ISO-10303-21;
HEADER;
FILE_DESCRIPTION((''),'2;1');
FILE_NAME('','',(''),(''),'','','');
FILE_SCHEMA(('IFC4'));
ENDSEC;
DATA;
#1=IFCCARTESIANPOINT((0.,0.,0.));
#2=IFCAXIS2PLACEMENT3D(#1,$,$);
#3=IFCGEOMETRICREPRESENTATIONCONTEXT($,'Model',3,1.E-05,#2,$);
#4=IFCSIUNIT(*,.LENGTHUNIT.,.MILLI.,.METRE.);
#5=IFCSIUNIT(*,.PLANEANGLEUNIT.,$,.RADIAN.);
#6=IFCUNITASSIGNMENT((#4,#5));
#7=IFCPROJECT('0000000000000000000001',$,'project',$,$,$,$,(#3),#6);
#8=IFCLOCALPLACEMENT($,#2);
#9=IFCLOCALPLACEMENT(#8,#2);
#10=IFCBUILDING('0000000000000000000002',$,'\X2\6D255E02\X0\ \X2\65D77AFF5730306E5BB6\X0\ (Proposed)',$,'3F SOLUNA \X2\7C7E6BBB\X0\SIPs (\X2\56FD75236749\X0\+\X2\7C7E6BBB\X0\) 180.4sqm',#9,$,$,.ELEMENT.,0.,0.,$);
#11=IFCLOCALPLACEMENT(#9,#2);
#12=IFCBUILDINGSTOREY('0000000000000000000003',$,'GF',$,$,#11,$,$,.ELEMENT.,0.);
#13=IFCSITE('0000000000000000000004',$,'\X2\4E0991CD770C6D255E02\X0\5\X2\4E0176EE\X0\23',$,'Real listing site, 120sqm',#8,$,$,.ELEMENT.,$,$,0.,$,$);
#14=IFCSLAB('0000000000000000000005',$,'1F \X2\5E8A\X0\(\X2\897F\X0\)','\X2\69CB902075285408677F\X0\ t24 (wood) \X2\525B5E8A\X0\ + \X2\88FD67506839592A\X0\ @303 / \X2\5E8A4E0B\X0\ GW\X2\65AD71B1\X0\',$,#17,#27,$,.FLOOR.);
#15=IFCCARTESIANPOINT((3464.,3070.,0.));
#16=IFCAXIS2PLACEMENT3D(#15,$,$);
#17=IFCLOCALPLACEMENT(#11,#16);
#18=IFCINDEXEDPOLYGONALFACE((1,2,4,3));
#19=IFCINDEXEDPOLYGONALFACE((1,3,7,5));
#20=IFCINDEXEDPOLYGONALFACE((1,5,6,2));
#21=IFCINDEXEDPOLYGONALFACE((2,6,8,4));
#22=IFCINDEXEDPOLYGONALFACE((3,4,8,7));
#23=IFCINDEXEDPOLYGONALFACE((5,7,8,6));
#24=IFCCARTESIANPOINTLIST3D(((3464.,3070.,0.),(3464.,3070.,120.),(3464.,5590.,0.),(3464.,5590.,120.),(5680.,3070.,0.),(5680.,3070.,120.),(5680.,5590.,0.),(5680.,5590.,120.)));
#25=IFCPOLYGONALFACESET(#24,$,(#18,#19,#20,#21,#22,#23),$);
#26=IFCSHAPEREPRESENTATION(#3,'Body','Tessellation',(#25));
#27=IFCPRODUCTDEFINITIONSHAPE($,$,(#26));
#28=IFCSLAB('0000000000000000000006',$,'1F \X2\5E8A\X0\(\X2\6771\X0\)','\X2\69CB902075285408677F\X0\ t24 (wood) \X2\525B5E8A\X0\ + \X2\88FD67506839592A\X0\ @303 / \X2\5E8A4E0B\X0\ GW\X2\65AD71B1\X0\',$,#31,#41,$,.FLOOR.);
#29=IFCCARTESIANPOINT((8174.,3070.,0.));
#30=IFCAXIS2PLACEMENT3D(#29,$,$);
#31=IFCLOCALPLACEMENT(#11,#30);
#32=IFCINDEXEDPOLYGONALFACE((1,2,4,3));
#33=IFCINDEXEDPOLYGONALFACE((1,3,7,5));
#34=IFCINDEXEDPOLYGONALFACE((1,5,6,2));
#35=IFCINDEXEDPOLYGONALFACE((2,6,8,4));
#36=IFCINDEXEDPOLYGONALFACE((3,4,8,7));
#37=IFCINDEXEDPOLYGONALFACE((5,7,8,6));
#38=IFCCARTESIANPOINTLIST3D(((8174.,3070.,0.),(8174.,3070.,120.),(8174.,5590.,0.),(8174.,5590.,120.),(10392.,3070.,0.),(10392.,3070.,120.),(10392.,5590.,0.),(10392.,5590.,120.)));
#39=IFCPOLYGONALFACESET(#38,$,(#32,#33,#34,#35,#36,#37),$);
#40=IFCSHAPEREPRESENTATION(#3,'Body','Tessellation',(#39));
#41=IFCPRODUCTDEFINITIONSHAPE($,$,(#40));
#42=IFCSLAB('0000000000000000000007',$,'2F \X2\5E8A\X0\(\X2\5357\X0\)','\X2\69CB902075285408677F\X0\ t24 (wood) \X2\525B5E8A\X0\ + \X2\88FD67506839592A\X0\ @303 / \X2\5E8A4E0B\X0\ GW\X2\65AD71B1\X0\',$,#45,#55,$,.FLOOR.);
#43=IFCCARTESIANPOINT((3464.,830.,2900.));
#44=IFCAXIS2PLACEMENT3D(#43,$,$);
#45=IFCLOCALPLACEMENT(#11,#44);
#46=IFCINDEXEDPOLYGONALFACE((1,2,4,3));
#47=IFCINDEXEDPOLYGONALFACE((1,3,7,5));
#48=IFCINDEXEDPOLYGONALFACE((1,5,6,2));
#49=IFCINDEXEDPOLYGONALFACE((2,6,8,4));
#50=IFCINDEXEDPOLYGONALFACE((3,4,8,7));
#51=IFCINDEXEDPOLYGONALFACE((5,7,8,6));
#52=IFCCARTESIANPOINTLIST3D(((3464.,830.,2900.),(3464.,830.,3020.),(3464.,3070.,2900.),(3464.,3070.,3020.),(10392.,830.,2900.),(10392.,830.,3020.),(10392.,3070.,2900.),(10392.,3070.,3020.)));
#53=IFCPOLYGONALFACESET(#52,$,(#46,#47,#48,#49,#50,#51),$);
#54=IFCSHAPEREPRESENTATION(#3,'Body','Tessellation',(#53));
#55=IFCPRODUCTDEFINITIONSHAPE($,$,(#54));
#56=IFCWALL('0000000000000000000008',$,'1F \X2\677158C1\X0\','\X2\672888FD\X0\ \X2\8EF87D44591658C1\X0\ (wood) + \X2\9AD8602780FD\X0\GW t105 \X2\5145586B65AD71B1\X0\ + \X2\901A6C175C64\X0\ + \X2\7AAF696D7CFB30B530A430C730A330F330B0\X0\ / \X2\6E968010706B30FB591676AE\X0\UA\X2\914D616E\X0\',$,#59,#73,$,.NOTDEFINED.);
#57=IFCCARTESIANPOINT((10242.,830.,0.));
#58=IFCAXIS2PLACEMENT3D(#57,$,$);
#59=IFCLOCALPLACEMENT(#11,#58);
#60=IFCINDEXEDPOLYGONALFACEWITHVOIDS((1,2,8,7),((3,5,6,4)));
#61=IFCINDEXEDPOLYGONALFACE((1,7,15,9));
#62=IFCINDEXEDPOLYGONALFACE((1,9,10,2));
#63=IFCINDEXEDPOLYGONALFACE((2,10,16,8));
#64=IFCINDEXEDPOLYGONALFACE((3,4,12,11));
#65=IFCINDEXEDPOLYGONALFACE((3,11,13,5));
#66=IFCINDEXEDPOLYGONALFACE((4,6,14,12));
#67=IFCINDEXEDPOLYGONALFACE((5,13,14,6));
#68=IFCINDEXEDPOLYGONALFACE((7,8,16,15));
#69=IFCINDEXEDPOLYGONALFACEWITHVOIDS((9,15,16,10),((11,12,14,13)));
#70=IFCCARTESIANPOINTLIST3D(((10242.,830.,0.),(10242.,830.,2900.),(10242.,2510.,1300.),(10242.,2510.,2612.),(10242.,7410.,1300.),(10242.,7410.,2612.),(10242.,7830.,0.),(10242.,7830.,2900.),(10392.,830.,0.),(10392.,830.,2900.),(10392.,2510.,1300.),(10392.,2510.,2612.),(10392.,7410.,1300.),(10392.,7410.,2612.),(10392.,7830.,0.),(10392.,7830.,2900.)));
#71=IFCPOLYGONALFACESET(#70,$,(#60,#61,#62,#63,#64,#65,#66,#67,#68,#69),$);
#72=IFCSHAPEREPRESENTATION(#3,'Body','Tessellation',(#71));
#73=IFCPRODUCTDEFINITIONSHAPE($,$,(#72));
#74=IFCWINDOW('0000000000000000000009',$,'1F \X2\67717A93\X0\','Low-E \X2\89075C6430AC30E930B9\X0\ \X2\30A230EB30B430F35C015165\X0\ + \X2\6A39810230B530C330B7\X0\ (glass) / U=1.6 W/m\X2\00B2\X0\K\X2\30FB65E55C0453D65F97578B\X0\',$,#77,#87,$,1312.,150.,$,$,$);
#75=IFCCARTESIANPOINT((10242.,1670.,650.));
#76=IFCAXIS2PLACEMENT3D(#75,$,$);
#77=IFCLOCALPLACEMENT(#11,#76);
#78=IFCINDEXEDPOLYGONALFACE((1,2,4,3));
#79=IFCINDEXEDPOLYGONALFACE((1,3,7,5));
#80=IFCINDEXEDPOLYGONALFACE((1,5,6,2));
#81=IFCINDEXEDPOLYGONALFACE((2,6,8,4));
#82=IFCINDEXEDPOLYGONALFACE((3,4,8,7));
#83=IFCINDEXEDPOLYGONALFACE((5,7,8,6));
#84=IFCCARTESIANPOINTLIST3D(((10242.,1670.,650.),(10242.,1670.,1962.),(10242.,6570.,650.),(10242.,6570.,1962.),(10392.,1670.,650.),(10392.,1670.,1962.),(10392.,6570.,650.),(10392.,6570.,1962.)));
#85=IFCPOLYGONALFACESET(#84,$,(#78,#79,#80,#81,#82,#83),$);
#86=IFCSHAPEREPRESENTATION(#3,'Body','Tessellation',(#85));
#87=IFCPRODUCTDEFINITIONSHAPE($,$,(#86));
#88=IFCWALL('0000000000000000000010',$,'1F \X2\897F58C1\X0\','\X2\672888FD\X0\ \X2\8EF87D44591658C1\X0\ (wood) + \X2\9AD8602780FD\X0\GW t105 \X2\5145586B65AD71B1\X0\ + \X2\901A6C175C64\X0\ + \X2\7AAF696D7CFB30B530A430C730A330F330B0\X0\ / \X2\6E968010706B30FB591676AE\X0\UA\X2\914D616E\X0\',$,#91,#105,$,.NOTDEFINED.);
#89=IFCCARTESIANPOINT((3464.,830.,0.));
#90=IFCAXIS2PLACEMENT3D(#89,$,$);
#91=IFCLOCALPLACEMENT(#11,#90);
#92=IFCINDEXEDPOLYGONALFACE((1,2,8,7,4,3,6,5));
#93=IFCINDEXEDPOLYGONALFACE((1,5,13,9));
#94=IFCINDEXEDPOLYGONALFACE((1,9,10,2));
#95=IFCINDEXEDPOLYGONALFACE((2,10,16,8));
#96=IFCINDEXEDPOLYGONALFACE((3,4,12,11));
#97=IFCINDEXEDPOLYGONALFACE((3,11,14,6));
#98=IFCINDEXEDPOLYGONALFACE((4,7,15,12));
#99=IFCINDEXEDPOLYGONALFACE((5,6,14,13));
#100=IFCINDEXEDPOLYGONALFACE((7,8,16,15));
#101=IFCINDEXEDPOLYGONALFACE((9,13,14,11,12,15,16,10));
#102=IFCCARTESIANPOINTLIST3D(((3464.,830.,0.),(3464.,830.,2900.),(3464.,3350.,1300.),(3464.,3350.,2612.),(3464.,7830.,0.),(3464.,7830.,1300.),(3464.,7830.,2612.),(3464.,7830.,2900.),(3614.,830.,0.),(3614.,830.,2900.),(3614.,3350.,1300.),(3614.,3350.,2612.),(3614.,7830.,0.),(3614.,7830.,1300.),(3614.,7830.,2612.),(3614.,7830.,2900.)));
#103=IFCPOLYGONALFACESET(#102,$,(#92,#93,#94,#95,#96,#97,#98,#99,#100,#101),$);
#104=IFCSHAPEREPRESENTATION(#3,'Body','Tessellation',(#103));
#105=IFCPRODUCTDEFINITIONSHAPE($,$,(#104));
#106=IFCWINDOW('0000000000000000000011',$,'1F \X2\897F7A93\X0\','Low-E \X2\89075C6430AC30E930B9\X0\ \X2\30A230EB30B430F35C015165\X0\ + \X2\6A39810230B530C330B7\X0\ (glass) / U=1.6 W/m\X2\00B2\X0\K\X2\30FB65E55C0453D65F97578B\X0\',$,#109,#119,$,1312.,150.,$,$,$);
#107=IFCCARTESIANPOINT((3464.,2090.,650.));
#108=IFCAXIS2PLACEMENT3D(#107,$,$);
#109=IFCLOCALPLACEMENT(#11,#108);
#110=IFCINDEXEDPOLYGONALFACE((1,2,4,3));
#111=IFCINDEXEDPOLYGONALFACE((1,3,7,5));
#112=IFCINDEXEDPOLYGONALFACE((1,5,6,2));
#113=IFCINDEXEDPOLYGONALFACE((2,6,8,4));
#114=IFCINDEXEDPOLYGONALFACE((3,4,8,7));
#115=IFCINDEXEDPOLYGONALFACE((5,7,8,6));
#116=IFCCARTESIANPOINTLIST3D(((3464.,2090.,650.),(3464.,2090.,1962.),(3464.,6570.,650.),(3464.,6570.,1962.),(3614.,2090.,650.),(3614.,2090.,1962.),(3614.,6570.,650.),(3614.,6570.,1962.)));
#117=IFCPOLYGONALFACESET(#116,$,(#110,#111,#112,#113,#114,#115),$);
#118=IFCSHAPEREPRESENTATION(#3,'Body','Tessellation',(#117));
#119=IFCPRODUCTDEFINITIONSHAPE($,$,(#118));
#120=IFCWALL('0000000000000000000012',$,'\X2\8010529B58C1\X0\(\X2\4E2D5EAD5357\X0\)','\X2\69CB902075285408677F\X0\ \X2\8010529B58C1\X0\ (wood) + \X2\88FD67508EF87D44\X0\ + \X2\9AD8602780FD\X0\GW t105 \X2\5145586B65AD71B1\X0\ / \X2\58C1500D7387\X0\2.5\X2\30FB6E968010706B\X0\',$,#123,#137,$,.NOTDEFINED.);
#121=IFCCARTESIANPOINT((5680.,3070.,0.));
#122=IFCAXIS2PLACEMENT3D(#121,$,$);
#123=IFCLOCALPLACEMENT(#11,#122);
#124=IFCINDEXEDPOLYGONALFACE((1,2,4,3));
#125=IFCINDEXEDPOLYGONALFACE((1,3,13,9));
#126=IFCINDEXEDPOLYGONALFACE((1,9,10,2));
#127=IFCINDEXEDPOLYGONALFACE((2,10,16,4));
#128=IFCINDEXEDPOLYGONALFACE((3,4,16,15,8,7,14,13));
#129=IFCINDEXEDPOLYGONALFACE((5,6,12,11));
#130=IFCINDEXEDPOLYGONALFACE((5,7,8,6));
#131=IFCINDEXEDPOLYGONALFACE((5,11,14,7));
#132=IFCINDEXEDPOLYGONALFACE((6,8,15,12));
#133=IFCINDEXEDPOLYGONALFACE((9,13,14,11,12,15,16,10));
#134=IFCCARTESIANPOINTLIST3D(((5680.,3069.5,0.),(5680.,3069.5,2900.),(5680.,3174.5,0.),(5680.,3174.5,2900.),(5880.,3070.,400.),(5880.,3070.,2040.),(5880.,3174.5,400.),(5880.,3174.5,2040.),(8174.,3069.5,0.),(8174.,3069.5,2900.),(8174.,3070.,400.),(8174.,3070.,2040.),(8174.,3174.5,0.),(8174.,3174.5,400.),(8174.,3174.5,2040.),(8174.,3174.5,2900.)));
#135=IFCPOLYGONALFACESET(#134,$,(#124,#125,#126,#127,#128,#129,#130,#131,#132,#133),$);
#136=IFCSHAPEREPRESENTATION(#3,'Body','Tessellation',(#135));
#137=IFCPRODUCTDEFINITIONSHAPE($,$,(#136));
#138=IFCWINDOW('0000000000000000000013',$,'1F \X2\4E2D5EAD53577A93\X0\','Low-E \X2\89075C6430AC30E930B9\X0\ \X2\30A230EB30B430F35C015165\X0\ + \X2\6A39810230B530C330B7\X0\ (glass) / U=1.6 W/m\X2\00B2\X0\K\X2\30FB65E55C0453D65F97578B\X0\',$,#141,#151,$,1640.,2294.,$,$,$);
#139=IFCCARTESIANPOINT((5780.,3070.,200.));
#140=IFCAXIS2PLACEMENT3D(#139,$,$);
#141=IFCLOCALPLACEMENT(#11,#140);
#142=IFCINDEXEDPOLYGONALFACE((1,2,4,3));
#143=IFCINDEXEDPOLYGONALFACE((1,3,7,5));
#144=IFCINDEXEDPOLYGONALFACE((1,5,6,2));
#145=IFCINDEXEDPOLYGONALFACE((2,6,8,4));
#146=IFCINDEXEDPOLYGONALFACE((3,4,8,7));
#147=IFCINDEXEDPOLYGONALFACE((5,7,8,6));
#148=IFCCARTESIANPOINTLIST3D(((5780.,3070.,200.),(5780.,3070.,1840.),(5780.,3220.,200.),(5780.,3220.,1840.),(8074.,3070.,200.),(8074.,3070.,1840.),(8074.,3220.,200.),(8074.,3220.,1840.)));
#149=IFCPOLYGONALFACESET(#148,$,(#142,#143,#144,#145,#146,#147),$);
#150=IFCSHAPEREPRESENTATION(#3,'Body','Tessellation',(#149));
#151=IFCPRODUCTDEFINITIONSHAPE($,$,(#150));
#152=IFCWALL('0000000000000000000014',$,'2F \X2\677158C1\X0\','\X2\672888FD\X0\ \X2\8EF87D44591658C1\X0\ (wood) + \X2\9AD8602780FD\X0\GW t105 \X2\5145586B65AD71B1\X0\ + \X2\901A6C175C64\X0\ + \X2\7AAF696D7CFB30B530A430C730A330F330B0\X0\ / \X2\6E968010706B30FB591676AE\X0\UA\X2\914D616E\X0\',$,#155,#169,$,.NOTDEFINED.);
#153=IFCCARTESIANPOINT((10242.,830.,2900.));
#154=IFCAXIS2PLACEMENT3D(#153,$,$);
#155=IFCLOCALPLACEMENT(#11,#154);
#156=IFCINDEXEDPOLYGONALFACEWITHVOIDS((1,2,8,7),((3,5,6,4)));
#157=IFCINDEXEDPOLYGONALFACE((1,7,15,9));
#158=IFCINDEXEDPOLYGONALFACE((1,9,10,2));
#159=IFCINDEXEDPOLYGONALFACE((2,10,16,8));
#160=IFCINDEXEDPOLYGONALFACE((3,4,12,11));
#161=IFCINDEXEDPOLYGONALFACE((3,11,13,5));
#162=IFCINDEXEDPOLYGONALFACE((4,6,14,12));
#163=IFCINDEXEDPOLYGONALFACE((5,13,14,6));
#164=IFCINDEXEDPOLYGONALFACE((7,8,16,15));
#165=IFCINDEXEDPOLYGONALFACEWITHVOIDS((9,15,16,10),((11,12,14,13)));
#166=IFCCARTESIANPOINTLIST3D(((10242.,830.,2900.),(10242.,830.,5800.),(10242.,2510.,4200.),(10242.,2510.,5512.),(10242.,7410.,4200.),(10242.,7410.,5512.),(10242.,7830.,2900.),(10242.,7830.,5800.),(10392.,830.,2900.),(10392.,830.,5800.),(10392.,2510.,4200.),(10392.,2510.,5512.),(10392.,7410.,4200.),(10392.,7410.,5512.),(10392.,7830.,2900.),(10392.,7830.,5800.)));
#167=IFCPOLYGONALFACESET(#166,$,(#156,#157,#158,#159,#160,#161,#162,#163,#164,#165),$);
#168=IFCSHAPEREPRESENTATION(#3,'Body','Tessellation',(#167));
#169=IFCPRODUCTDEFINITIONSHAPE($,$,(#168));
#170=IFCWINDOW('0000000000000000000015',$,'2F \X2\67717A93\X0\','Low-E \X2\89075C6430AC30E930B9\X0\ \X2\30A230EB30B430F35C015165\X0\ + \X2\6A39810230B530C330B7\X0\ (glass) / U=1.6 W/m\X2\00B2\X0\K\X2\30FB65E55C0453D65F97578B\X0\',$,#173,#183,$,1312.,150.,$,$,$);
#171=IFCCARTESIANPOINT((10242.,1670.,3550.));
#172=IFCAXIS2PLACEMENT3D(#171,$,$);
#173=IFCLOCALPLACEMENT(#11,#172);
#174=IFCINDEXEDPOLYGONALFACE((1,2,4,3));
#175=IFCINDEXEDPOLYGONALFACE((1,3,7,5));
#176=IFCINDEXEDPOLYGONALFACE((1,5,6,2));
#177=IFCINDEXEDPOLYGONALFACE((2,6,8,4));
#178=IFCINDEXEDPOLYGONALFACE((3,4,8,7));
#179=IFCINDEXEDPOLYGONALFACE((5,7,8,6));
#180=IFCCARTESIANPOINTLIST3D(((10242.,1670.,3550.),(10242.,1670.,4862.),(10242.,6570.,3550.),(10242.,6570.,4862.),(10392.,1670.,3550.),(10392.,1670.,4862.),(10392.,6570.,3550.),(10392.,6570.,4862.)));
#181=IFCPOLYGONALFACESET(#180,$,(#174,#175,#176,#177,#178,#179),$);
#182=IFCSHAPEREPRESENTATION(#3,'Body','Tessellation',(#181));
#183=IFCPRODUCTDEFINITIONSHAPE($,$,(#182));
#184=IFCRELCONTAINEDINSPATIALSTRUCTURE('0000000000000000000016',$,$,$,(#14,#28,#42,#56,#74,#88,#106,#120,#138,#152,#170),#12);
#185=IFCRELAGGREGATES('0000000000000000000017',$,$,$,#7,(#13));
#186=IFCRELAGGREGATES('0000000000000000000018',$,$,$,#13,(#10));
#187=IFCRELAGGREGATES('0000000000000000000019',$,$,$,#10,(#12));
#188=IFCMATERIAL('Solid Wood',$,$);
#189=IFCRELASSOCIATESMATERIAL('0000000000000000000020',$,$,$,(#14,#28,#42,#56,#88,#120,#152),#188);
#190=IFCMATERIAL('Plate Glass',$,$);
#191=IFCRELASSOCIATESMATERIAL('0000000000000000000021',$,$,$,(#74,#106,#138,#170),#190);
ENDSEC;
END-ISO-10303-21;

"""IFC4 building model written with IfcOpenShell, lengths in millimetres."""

from ifc_helpers import new_model, si_unit, frame, frame_2d, origin, place, context, project, spatial, rectangle, extrude, material, element, fill, save


model = new_model("IFC4")

# Units and contexts
model_context = context("Model", 3, precision=1e-05, world=origin())
ifc_project = project(units=[si_unit("LENGTHUNIT", "METRE", prefix="MILLI"), si_unit("PLANEANGLEUNIT", "RADIAN")], contexts=[model_context])

# Site, building, storey
site_placement = place(None, origin())
site = spatial("IfcSite", under=ifc_project, at=site_placement, Name="三重県津市5丁目23", ObjectType="Real listing site, 120sqm", CompositionType="ELEMENT", RefElevation=0.0)
building_placement = place(site_placement, origin())
building = spatial("IfcBuilding", under=site, at=building_placement, Name="津市 旗竿地の家 (Proposed)", ObjectType="3F SOLUNA 籾殻SIPs (国産杉+籾殻) 180.4sqm", CompositionType="ELEMENT", ElevationOfRefHeight=0.0, ElevationOfTerrain=0.0)
storey_placement = place(building_placement, origin())
storey = spatial("IfcBuildingStorey", under=building, at=storey_placement, Name="GF", CompositionType="ELEMENT", Elevation=0.0)

# Slabs
ifc_material_1 = material(Name="Solid Wood")
slab_1_placement = place(storey_placement, frame((3464.0, 3070.0, 0.0)))
element("IfcSlab", 1, at=slab_1_placement, inside=storey, material=ifc_material_1, Name="1F 床(西)", Description="構造用合板 t24 (wood) 剛床 + 製材根太 @303 / 床下 GW断熱", PredefinedType="FLOOR", context=model_context, shape_type="SweptSolid", body=[
    extrude(rectangle(XDim=2216.0, YDim=2520.0, at=frame_2d((1108.0, 1260.0))), frame((3464.0, 3070.0, 0.0)), (0.0, 0.0, 1.0), 120.0),
])
slab_2_placement = place(storey_placement, frame((8174.0, 3070.0, 0.0)))
element("IfcSlab", 2, at=slab_2_placement, inside=storey, material=ifc_material_1, Name="1F 床(東)", Description="構造用合板 t24 (wood) 剛床 + 製材根太 @303 / 床下 GW断熱", PredefinedType="FLOOR", context=model_context, shape_type="SweptSolid", body=[
    extrude(rectangle(XDim=2218.0, YDim=2520.0, at=frame_2d((1109.0, 1260.0))), frame((8174.0, 3070.0, 0.0)), (0.0, 0.0, 1.0), 120.0),
])
slab_3_placement = place(storey_placement, frame((3464.0, 830.0, 2900.0)))
element("IfcSlab", 3, at=slab_3_placement, inside=storey, material=ifc_material_1, Name="2F 床(南)", Description="構造用合板 t24 (wood) 剛床 + 製材根太 @303 / 床下 GW断熱", PredefinedType="FLOOR", context=model_context, shape_type="SweptSolid", body=[
    extrude(rectangle(XDim=6928.0, YDim=2240.0, at=frame_2d((3464.0, 1120.0))), frame((3464.0, 830.0, 2900.0)), (0.0, 0.0, 1.0), 120.0),
])

# Shared definitions
ifc_material_2 = material(Name="Plate Glass")

# Walls, openings, windows
wall_1_placement = place(storey_placement, frame((10242.0, 830.0, 0.0)))
wall_1 = element("IfcWall", 4, at=wall_1_placement, inside=storey, material=ifc_material_1, Name="1F 東壁", Description="木製 軸組外壁 (wood) + 高性能GW t105 充填断熱 + 通気層 + 窯業系サイディング / 準耐火・外皮UA配慮", PredefinedType="NOTDEFINED", context=model_context, shape_type="SweptSolid", body=[
    extrude(rectangle(XDim=150.0, YDim=7000.0, at=frame_2d((75.0, 3500.0))), frame((10242.0, 830.0, 0.0)), (0.0, 0.0, 1.0), 2900.0),
])
opening_1_placement = place(storey_placement, frame((10242.0, 1670.0, 650.0)))
opening_1 = element("IfcOpeningElement", 5, at=opening_1_placement, cuts=wall_1, PredefinedType="NOTDEFINED", context=model_context, shape_type="SweptSolid", body=[
    extrude(rectangle(XDim=150.0, YDim=4900.0, at=frame_2d((75.0, 2450.0))), frame((10242.0, 1670.0, 650.0)), (0.0, 0.0, 1.0), 1312.0),
])
window_1_placement = place(storey_placement, frame((10242.0, 1670.0, 650.0)))
window_1 = element("IfcWindow", 6, at=window_1_placement, inside=storey, material=ifc_material_2, Name="1F 東窓", Description="Low-E 複層ガラス アルゴン封入 + 樹脂サッシ (glass) / U=1.6 W/m²K・日射取得型", OverallHeight=1312.0, OverallWidth=150.0, context=model_context, shape_type="SweptSolid", body=[
    extrude(rectangle(XDim=150.0, YDim=4900.0, at=frame_2d((75.0, 2450.0))), frame((10242.0, 1670.0, 650.0)), (0.0, 0.0, 1.0), 1312.0),
])
fill(opening_1, window_1)
wall_2_placement = place(storey_placement, frame((3464.0, 830.0, 0.0)))
wall_2 = element("IfcWall", 7, at=wall_2_placement, inside=storey, material=ifc_material_1, Name="1F 西壁", Description="木製 軸組外壁 (wood) + 高性能GW t105 充填断熱 + 通気層 + 窯業系サイディング / 準耐火・外皮UA配慮", PredefinedType="NOTDEFINED", context=model_context, shape_type="SweptSolid", body=[
    extrude(rectangle(XDim=150.0, YDim=7000.0, at=frame_2d((75.0, 3500.0))), frame((3464.0, 830.0, 0.0)), (0.0, 0.0, 1.0), 2900.0),
])
opening_2_placement = place(storey_placement, frame((3464.0, 2090.0, 650.0)))
opening_2 = element("IfcOpeningElement", 8, at=opening_2_placement, cuts=wall_2, PredefinedType="NOTDEFINED", context=model_context, shape_type="SweptSolid", body=[
    extrude(rectangle(XDim=150.0, YDim=4480.0, at=frame_2d((75.0, 2240.0))), frame((3464.0, 2090.0, 650.0)), (0.0, 0.0, 1.0), 1312.0),
])
window_2_placement = place(storey_placement, frame((3464.0, 2090.0, 650.0)))
window_2 = element("IfcWindow", 9, at=window_2_placement, inside=storey, material=ifc_material_2, Name="1F 西窓", Description="Low-E 複層ガラス アルゴン封入 + 樹脂サッシ (glass) / U=1.6 W/m²K・日射取得型", OverallHeight=1312.0, OverallWidth=150.0, context=model_context, shape_type="SweptSolid", body=[
    extrude(rectangle(XDim=150.0, YDim=4480.0, at=frame_2d((75.0, 2240.0))), frame((3464.0, 2090.0, 650.0)), (0.0, 0.0, 1.0), 1312.0),
])
fill(opening_2, window_2)
wall_3_placement = place(storey_placement, frame((5680.0, 3070.0, 0.0)))
wall_3 = element("IfcWall", 10, at=wall_3_placement, inside=storey, material=ifc_material_1, Name="耐力壁(中庭南)", Description="構造用合板 耐力壁 (wood) + 製材軸組 + 高性能GW t105 充填断熱 / 壁倍率2.5・準耐火", PredefinedType="NOTDEFINED", context=model_context, shape_type="SweptSolid", body=[
    extrude(rectangle(XDim=2494.0, YDim=105.0, at=frame_2d((1247.0, 52.0))), frame((5680.0, 3070.0, 0.0)), (0.0, 0.0, 1.0), 2900.0),
])
opening_3_placement = place(storey_placement, frame((5780.0, 3070.0, 200.0)))
opening_3 = element("IfcOpeningElement", 11, at=opening_3_placement, cuts=wall_3, PredefinedType="NOTDEFINED", context=model_context, shape_type="SweptSolid", body=[
    extrude(rectangle(XDim=2294.0, YDim=150.0, at=frame_2d((1147.0, 75.0))), frame((5780.0, 3070.0, 200.0)), (0.0, 0.0, 1.0), 1640.0),
])
window_3_placement = place(storey_placement, frame((5780.0, 3070.0, 200.0)))
window_3 = element("IfcWindow", 12, at=window_3_placement, inside=storey, material=ifc_material_2, Name="1F 中庭南窓", Description="Low-E 複層ガラス アルゴン封入 + 樹脂サッシ (glass) / U=1.6 W/m²K・日射取得型", OverallHeight=1640.0, OverallWidth=2294.0, context=model_context, shape_type="SweptSolid", body=[
    extrude(rectangle(XDim=2294.0, YDim=150.0, at=frame_2d((1147.0, 75.0))), frame((5780.0, 3070.0, 200.0)), (0.0, 0.0, 1.0), 1640.0),
])
fill(opening_3, window_3)
wall_4_placement = place(storey_placement, frame((10242.0, 830.0, 2900.0)))
wall_4 = element("IfcWall", 13, at=wall_4_placement, inside=storey, material=ifc_material_1, Name="2F 東壁", Description="木製 軸組外壁 (wood) + 高性能GW t105 充填断熱 + 通気層 + 窯業系サイディング / 準耐火・外皮UA配慮", PredefinedType="NOTDEFINED", context=model_context, shape_type="SweptSolid", body=[
    extrude(rectangle(XDim=150.0, YDim=7000.0, at=frame_2d((75.0, 3500.0))), frame((10242.0, 830.0, 2900.0)), (0.0, 0.0, 1.0), 2900.0),
])
opening_4_placement = place(storey_placement, frame((10242.0, 1670.0, 3550.0)))
opening_4 = element("IfcOpeningElement", 14, at=opening_4_placement, cuts=wall_4, PredefinedType="NOTDEFINED", context=model_context, shape_type="SweptSolid", body=[
    extrude(rectangle(XDim=150.0, YDim=4900.0, at=frame_2d((75.0, 2450.0))), frame((10242.0, 1670.0, 3550.0)), (0.0, 0.0, 1.0), 1312.0),
])
window_4_placement = place(storey_placement, frame((10242.0, 1670.0, 3550.0)))
window_4 = element("IfcWindow", 15, at=window_4_placement, inside=storey, material=ifc_material_2, Name="2F 東窓", Description="Low-E 複層ガラス アルゴン封入 + 樹脂サッシ (glass) / U=1.6 W/m²K・日射取得型", OverallHeight=1312.0, OverallWidth=150.0, context=model_context, shape_type="SweptSolid", body=[
    extrude(rectangle(XDim=150.0, YDim=4900.0, at=frame_2d((75.0, 2450.0))), frame((10242.0, 1670.0, 3550.0)), (0.0, 0.0, 1.0), 1312.0),
])
fill(opening_4, window_4)

save(model, "model.ifc")
